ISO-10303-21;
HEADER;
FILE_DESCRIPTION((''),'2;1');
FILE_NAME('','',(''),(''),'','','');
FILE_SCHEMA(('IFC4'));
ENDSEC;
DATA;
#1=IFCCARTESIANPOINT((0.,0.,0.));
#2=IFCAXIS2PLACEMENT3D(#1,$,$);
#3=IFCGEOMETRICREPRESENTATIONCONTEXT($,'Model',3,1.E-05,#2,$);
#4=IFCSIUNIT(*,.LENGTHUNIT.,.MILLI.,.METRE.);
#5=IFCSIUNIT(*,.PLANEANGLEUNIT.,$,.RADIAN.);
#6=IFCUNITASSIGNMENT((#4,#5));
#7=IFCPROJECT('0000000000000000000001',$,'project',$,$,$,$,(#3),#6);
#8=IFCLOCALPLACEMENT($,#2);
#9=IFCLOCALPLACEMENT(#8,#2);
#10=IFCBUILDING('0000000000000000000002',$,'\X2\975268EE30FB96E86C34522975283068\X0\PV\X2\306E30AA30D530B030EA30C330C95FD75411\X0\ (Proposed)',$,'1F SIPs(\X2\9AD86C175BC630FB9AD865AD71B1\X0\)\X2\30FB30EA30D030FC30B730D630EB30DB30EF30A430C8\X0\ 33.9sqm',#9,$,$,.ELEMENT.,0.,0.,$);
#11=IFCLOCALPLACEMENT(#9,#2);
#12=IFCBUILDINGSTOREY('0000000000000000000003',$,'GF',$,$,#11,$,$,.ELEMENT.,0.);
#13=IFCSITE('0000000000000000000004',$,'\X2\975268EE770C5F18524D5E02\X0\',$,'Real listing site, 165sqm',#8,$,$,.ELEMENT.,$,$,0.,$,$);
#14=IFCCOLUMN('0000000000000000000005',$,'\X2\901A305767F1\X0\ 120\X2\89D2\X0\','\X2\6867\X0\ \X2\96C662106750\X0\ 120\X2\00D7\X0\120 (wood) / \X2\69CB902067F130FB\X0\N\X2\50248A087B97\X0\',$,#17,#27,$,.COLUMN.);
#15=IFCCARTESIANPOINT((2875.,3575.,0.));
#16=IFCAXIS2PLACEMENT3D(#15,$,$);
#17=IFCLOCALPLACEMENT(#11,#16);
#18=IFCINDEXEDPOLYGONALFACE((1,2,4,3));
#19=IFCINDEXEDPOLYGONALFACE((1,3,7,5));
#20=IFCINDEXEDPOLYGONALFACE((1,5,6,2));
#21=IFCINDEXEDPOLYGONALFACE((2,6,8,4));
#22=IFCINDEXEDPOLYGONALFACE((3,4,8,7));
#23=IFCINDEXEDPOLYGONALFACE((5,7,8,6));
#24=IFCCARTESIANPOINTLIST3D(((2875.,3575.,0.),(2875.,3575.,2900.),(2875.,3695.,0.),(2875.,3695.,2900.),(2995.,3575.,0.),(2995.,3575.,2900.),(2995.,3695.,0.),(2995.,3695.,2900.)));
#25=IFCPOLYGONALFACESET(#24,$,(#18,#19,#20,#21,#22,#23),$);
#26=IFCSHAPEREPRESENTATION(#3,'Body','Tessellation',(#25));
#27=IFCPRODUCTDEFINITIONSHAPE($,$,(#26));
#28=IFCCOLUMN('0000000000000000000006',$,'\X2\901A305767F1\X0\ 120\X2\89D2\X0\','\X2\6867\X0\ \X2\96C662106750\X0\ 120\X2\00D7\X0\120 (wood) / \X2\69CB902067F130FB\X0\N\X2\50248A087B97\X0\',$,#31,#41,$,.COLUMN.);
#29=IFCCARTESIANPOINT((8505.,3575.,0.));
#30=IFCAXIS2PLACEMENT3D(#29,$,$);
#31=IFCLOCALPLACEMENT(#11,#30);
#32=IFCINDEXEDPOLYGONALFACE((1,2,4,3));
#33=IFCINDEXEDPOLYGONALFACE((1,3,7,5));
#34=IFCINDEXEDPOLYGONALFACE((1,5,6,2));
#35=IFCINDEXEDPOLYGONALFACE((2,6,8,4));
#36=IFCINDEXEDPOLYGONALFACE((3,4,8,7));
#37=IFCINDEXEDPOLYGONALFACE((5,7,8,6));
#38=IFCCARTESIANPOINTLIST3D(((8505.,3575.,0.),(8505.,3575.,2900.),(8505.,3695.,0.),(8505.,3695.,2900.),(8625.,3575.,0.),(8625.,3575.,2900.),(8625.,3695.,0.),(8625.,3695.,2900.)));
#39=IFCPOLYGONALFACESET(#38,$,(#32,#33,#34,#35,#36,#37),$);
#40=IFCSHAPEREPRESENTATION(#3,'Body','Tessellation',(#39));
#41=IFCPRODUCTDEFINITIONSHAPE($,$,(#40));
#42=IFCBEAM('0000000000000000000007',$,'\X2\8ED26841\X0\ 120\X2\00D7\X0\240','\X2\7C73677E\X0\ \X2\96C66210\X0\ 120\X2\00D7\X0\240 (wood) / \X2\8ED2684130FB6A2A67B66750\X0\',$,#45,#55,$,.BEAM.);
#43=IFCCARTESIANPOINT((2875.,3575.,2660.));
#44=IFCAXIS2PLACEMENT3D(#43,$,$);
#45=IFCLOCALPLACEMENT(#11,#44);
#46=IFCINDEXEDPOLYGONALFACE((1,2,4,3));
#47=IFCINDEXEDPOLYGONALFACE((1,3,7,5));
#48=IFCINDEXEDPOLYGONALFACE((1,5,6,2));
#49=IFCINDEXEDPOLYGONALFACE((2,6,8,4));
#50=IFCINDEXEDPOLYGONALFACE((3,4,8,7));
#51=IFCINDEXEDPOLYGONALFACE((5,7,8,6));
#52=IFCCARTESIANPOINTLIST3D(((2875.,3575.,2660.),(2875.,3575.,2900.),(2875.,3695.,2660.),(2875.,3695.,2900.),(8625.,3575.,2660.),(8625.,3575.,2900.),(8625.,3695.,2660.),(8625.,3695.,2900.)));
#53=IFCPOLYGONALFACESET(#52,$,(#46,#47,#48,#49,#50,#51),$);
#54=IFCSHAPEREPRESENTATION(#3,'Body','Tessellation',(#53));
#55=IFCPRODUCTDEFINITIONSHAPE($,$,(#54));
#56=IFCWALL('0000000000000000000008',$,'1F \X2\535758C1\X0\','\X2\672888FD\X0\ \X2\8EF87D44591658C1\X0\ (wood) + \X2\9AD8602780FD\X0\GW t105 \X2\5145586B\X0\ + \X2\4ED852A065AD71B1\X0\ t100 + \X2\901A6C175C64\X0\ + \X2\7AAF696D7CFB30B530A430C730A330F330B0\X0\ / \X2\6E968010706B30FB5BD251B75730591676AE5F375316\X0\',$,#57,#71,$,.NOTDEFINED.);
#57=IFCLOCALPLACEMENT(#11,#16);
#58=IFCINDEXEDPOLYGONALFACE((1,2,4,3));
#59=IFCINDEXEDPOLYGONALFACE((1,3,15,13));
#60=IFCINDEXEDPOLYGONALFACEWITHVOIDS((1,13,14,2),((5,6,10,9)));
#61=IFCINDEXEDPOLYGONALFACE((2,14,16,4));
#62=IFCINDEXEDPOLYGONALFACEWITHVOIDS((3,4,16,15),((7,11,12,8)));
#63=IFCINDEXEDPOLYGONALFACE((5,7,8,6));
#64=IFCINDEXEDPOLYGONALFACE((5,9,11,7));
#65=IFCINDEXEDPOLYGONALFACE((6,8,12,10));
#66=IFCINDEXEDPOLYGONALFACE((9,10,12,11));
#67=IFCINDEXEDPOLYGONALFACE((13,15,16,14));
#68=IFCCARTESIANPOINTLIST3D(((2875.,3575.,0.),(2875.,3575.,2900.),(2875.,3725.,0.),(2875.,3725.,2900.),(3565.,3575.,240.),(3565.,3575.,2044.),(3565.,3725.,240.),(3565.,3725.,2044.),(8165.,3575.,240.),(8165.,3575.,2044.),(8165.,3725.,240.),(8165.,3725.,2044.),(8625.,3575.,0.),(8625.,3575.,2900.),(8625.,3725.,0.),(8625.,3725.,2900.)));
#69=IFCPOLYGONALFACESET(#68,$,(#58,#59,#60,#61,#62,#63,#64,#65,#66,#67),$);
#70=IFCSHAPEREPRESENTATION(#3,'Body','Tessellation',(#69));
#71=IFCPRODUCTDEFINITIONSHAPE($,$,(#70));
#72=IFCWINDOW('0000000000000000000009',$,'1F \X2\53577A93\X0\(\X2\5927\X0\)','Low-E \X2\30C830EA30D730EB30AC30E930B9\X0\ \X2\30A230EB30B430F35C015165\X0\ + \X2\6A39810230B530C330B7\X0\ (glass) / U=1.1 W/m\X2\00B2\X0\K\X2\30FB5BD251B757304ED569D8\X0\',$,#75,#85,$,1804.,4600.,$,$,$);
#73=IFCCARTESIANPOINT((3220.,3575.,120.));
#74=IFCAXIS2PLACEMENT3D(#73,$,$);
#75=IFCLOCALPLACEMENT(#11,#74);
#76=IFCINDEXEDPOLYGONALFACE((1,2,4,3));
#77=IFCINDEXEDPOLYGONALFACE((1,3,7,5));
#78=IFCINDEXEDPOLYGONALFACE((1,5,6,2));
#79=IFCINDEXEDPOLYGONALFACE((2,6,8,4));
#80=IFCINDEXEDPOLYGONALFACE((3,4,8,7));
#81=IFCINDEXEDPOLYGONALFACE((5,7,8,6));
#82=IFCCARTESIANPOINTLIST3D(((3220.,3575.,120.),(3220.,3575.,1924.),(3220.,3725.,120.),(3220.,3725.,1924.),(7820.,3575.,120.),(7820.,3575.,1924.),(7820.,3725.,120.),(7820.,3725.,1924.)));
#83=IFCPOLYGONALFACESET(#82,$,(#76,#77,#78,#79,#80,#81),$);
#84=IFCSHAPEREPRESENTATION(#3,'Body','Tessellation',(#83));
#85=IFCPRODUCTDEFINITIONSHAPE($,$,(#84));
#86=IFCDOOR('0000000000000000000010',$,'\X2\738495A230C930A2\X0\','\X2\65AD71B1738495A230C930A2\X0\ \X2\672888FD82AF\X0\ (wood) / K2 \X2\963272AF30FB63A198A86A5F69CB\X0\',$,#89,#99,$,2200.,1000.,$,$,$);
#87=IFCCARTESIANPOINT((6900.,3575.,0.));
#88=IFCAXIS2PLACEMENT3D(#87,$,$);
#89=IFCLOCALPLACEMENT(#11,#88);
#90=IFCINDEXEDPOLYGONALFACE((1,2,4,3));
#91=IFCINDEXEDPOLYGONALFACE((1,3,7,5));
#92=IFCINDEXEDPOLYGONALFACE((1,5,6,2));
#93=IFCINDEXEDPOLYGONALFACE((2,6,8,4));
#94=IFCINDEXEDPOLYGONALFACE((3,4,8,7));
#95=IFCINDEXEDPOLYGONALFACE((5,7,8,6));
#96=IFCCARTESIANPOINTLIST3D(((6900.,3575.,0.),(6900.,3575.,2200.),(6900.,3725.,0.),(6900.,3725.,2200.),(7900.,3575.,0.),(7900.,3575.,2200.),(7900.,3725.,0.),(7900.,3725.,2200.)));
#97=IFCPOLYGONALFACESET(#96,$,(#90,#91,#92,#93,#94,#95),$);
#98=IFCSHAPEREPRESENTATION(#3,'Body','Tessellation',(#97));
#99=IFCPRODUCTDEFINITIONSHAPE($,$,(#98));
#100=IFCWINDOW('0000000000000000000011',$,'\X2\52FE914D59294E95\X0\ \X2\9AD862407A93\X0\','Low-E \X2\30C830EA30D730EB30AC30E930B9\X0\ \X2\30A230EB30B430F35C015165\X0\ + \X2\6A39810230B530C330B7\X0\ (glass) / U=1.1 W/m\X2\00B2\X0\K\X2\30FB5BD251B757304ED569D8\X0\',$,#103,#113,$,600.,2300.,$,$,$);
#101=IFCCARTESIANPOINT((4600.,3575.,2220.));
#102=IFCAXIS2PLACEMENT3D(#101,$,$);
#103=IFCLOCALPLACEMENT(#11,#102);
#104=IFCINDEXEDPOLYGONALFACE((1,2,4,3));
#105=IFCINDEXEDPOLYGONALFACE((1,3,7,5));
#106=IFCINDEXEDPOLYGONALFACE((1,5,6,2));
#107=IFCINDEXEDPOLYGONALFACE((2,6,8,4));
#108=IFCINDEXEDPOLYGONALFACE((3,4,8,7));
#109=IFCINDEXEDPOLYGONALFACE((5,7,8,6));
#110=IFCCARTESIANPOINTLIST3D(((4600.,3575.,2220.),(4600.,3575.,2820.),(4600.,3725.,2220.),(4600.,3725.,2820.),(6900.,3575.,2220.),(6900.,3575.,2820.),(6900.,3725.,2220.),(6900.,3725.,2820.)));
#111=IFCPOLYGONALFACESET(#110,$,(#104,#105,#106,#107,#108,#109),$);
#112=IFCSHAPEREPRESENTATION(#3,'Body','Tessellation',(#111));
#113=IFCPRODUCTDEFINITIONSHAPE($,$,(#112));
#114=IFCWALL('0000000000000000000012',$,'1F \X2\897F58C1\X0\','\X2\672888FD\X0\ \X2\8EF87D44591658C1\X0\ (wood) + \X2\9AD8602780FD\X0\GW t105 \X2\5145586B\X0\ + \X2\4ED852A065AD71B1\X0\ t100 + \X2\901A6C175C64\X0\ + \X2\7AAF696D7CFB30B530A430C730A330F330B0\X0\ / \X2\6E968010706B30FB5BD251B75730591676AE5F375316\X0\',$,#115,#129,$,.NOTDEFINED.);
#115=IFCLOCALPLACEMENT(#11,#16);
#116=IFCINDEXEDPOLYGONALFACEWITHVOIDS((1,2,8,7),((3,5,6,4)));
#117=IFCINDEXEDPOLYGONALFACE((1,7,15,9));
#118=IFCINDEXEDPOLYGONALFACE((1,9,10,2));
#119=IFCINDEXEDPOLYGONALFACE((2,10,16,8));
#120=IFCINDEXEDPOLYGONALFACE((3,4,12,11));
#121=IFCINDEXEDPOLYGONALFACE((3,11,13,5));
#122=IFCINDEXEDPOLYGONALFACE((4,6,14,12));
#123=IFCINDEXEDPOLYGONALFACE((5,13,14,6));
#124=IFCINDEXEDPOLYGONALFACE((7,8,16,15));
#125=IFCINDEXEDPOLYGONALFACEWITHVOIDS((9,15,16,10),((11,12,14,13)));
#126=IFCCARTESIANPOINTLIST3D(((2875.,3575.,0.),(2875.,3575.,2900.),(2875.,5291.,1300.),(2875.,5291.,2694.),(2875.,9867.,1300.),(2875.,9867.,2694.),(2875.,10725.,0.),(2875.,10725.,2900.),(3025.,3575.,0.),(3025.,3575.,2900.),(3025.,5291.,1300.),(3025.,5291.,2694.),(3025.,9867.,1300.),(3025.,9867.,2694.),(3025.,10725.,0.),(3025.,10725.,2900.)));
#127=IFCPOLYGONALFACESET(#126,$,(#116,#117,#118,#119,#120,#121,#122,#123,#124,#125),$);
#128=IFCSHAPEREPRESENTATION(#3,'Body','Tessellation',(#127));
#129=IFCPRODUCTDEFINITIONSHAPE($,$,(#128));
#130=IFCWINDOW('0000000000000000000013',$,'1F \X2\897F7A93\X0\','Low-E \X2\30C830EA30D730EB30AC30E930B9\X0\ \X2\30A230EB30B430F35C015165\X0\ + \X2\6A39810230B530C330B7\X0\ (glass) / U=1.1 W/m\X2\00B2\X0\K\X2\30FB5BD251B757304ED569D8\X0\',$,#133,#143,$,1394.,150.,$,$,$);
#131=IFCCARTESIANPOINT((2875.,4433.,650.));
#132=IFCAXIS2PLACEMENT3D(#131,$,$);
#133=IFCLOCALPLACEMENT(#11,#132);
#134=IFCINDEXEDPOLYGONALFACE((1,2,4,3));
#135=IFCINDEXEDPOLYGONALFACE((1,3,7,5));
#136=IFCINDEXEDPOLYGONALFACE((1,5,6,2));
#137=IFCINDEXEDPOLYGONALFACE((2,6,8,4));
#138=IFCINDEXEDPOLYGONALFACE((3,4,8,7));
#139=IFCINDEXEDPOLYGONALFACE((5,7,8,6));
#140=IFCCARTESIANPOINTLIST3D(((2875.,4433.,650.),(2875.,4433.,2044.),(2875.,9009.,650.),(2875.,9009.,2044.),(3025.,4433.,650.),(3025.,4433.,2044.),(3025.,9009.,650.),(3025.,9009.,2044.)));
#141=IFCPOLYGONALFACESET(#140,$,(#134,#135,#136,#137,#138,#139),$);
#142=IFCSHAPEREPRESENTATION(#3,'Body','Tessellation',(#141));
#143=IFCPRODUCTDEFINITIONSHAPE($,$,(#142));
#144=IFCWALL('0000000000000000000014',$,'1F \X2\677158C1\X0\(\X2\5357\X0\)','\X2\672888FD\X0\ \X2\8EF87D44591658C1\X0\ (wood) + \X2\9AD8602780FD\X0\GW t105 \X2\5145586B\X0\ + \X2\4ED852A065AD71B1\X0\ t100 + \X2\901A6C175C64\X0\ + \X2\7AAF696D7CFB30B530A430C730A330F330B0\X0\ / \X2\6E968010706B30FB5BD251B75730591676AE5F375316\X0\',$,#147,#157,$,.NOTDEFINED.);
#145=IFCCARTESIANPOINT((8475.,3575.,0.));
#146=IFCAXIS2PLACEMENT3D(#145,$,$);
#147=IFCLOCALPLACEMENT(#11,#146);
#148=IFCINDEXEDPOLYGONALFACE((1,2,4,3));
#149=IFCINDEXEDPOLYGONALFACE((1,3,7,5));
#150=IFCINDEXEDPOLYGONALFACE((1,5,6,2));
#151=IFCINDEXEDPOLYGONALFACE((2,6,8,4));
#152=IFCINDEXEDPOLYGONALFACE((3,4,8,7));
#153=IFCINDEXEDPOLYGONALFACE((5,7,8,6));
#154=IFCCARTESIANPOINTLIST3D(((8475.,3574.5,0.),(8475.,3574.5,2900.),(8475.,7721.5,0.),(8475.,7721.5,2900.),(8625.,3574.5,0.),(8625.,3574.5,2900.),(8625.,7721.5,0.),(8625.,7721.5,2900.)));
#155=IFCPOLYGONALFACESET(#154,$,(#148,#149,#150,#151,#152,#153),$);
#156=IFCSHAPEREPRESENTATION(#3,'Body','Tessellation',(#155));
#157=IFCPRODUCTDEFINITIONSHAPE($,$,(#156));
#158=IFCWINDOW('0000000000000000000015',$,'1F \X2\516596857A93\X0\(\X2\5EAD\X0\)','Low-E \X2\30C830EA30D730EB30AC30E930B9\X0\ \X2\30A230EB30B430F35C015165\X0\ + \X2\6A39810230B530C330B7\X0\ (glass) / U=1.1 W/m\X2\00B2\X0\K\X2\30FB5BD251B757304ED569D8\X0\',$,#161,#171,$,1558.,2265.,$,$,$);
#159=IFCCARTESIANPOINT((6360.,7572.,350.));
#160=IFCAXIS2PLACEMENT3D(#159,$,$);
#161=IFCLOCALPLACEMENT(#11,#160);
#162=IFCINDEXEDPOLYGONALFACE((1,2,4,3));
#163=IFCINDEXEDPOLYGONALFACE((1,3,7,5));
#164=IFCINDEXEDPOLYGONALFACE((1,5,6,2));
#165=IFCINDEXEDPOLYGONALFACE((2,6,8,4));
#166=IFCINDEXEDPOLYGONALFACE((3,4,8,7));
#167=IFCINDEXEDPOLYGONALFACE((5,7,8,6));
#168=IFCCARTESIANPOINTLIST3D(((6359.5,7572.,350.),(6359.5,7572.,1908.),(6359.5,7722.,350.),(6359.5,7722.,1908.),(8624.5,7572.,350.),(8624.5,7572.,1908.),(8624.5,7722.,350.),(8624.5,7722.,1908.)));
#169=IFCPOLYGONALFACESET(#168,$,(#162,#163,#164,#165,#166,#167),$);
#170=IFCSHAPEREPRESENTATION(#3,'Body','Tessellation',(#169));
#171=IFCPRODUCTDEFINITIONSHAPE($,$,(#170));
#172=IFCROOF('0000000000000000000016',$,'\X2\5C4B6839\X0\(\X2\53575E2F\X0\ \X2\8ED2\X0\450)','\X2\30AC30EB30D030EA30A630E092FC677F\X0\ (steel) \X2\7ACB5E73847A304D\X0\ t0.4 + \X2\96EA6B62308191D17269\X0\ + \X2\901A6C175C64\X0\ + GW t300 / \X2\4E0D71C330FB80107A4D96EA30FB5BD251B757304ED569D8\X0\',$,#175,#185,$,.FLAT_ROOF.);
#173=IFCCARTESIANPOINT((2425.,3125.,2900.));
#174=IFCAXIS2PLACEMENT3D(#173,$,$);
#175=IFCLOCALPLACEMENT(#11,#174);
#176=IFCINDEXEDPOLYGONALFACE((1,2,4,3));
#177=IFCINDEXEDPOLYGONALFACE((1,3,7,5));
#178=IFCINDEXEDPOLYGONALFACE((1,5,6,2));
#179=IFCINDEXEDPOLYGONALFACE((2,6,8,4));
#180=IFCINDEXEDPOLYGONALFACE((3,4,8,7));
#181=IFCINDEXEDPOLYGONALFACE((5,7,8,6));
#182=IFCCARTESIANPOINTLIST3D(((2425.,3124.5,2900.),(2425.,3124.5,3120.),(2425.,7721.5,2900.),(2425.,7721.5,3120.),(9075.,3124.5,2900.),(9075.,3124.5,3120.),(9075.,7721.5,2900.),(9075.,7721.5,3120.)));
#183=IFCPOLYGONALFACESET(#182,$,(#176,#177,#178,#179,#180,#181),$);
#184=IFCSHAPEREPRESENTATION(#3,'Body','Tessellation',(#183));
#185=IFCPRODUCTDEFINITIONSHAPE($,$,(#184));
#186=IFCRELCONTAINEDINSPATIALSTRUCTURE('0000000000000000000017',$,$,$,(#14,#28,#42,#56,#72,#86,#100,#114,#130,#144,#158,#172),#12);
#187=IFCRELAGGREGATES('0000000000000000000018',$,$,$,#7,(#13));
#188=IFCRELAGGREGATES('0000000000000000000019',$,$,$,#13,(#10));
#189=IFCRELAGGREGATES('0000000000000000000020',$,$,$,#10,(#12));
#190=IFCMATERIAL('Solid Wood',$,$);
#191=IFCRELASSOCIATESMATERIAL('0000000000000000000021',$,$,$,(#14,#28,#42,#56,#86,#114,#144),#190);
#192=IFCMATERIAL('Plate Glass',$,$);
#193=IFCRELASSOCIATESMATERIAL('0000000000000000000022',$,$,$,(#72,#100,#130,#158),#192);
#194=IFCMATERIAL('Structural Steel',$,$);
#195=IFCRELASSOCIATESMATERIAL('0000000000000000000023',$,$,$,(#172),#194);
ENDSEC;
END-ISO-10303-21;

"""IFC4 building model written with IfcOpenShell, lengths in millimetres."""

from ifc_helpers import new_model, si_unit, frame, frame_2d, origin, place, context, project, spatial, rectangle, extrude, material, element, fill, save


model = new_model("IFC4")

# Units and contexts
model_context = context("Model", 3, precision=1e-05, world=origin())
ifc_project = project(units=[si_unit("LENGTHUNIT", "METRE", prefix="MILLI"), si_unit("PLANEANGLEUNIT", "RADIAN")], contexts=[model_context])

# Site, building, storey
site_placement = place(None, origin())
site = spatial("IfcSite", under=ifc_project, at=site_placement, Name="青森県弘前市", ObjectType="Real listing site, 165sqm", CompositionType="ELEMENT", RefElevation=0.0)
building_placement = place(site_placement, origin())
building = spatial("IfcBuilding", under=site, at=building_placement, Name="青森・雨水利用とPVのオフグリッド志向 (Proposed)", ObjectType="1F SIPs(高気密・高断熱)・リバーシブルホワイト 33.9sqm", CompositionType="ELEMENT", ElevationOfRefHeight=0.0, ElevationOfTerrain=0.0)
storey_placement = place(building_placement, origin())
storey = spatial("IfcBuildingStorey", under=building, at=storey_placement, Name="GF", CompositionType="ELEMENT", Elevation=0.0)

# Columns
ifc_material_1 = material(Name="Solid Wood")
column_1_placement = place(storey_placement, frame((2875.0, 3575.0, 0.0)))
element("IfcColumn", 1, at=column_1_placement, inside=storey, material=ifc_material_1, Name="通し柱 120角", Description="桧 集成材 120×120 (wood) / 構造柱・N値計算", PredefinedType="COLUMN", context=model_context, shape_type="SweptSolid", body=[
    extrude(rectangle(XDim=120.0, YDim=120.0, at=frame_2d((60.0, 60.0))), frame((2875.0, 3575.0, 0.0)), (0.0, 0.0, 1.0), 2900.0),
])
column_2_placement = place(storey_placement, frame((8505.0, 3575.0, 0.0)))
element("IfcColumn", 2, at=column_2_placement, inside=storey, material=ifc_material_1, Name="通し柱 120角", Description="桧 集成材 120×120 (wood) / 構造柱・N値計算", PredefinedType="COLUMN", context=model_context, shape_type="SweptSolid", body=[
    extrude(rectangle(XDim=120.0, YDim=120.0, at=frame_2d((60.0, 60.0))), frame((8505.0, 3575.0, 0.0)), (0.0, 0.0, 1.0), 2900.0),
])

# Beam
beam_1_placement = place(storey_placement, frame((2875.0, 3575.0, 2660.0)))
element("IfcBeam", 3, at=beam_1_placement, inside=storey, material=ifc_material_1, Name="軒桁 120×240", Description="米松 集成 120×240 (wood) / 軒桁・横架材", PredefinedType="BEAM", context=model_context, shape_type="SweptSolid", body=[
    extrude(rectangle(XDim=5750.0, YDim=120.0, at=frame_2d((2875.0, 60.0))), frame((2875.0, 3575.0, 2660.0)), (0.0, 0.0, 1.0), 240.0),
])

# Wall, openings, windows, door
wall_1_placement = place(storey_placement, frame((2875.0, 3575.0, 0.0)))
wall_1 = element("IfcWall", 4, at=wall_1_placement, inside=storey, material=ifc_material_1, Name="1F 南壁", Description="木製 軸組外壁 (wood) + 高性能GW t105 充填 + 付加断熱 t100 + 通気層 + 窯業系サイディング / 準耐火・寒冷地外皮強化", PredefinedType="NOTDEFINED", context=model_context, shape_type="SweptSolid", body=[
    extrude(rectangle(XDim=5750.0, YDim=150.0, at=frame_2d((2875.0, 75.0))), frame((2875.0, 3575.0, 0.0)), (0.0, 0.0, 1.0), 2900.0),
])
opening_1_placement = place(storey_placement, frame((3220.0, 3575.0, 120.0)))
opening_1 = element("IfcOpeningElement", 5, at=opening_1_placement, cuts=wall_1, PredefinedType="NOTDEFINED", context=model_context, shape_type="SweptSolid", body=[
    extrude(rectangle(XDim=4600.0, YDim=150.0, at=frame_2d((2300.0, 75.0))), frame((3220.0, 3575.0, 120.0)), (0.0, 0.0, 1.0), 1804.0),
])
opening_2_placement = place(storey_placement, frame((6900.0, 3575.0, 0.0)))
opening_2 = element("IfcOpeningElement", 6, at=opening_2_placement, cuts=wall_1, PredefinedType="NOTDEFINED", context=model_context, shape_type="SweptSolid", body=[
    extrude(rectangle(XDim=1000.0, YDim=150.0, at=frame_2d((500.0, 75.0))), frame((6900.0, 3575.0, 0.0)), (0.0, 0.0, 1.0), 2200.0),
])
opening_3_placement = place(storey_placement, frame((4600.0, 3575.0, 2220.0)))
opening_3 = element("IfcOpeningElement", 7, at=opening_3_placement, cuts=wall_1, PredefinedType="NOTDEFINED", context=model_context, shape_type="SweptSolid", body=[
    extrude(rectangle(XDim=2300.0, YDim=150.0, at=frame_2d((1150.0, 75.0))), frame((4600.0, 3575.0, 2220.0)), (0.0, 0.0, 1.0), 600.0),
])
ifc_material_2 = material(Name="Plate Glass")
window_1_placement = place(storey_placement, frame((3220.0, 3575.0, 120.0)))
window_1 = element("IfcWindow", 8, at=window_1_placement, inside=storey, material=ifc_material_2, Name="1F 南窓(大)", Description="Low-E トリプルガラス アルゴン封入 + 樹脂サッシ (glass) / U=1.1 W/m²K・寒冷地仕様", OverallHeight=1804.0, OverallWidth=4600.0, context=model_context, shape_type="SweptSolid", body=[
    extrude(rectangle(XDim=4600.0, YDim=150.0, at=frame_2d((2300.0, 75.0))), frame((3220.0, 3575.0, 120.0)), (0.0, 0.0, 1.0), 1804.0),
])
fill(opening_1, window_1)
door_1_placement = place(storey_placement, frame((6900.0, 3575.0, 0.0)))
door_1 = element("IfcDoor", 9, at=door_1_placement, inside=storey, material=ifc_material_1, Name="玄関ドア", Description="断熱玄関ドア 木製芯 (wood) / K2 防犯・採風機構", OverallHeight=2200.0, OverallWidth=1000.0, context=model_context, shape_type="SweptSolid", body=[
    extrude(rectangle(XDim=1000.0, YDim=150.0, at=frame_2d((500.0, 75.0))), frame((6900.0, 3575.0, 0.0)), (0.0, 0.0, 1.0), 2200.0),
])
fill(opening_2, door_1)
window_2_placement = place(storey_placement, frame((4600.0, 3575.0, 2220.0)))
window_2 = element("IfcWindow", 10, at=window_2_placement, inside=storey, material=ifc_material_2, Name="勾配天井 高所窓", Description="Low-E トリプルガラス アルゴン封入 + 樹脂サッシ (glass) / U=1.1 W/m²K・寒冷地仕様", OverallHeight=600.0, OverallWidth=2300.0, context=model_context, shape_type="SweptSolid", body=[
    extrude(rectangle(XDim=2300.0, YDim=150.0, at=frame_2d((1150.0, 75.0))), frame((4600.0, 3575.0, 2220.0)), (0.0, 0.0, 1.0), 600.0),
])
fill(opening_3, window_2)

# Walls, openings, windows
wall_2_placement = place(storey_placement, frame((2875.0, 3575.0, 0.0)))
wall_2 = element("IfcWall", 11, at=wall_2_placement, inside=storey, material=ifc_material_1, Name="1F 西壁", Description="木製 軸組外壁 (wood) + 高性能GW t105 充填 + 付加断熱 t100 + 通気層 + 窯業系サイディング / 準耐火・寒冷地外皮強化", PredefinedType="NOTDEFINED", context=model_context, shape_type="SweptSolid", body=[
    extrude(rectangle(XDim=150.0, YDim=7150.0, at=frame_2d((75.0, 3575.0))), frame((2875.0, 3575.0, 0.0)), (0.0, 0.0, 1.0), 2900.0),
])
opening_4_placement = place(storey_placement, frame((2875.0, 4433.0, 650.0)))
opening_4 = element("IfcOpeningElement", 12, at=opening_4_placement, cuts=wall_2, PredefinedType="NOTDEFINED", context=model_context, shape_type="SweptSolid", body=[
    extrude(rectangle(XDim=150.0, YDim=4576.0, at=frame_2d((75.0, 2288.0))), frame((2875.0, 4433.0, 650.0)), (0.0, 0.0, 1.0), 1394.0),
])
window_3_placement = place(storey_placement, frame((2875.0, 4433.0, 650.0)))
window_3 = element("IfcWindow", 13, at=window_3_placement, inside=storey, material=ifc_material_2, Name="1F 西窓", Description="Low-E トリプルガラス アルゴン封入 + 樹脂サッシ (glass) / U=1.1 W/m²K・寒冷地仕様", OverallHeight=1394.0, OverallWidth=150.0, context=model_context, shape_type="SweptSolid", body=[
    extrude(rectangle(XDim=150.0, YDim=4576.0, at=frame_2d((75.0, 2288.0))), frame((2875.0, 4433.0, 650.0)), (0.0, 0.0, 1.0), 1394.0),
])
fill(opening_4, window_3)
wall_3_placement = place(storey_placement, frame((8475.0, 3575.0, 0.0)))
wall_3 = element("IfcWall", 14, at=wall_3_placement, inside=storey, material=ifc_material_1, Name="1F 東壁(南)", Description="木製 軸組外壁 (wood) + 高性能GW t105 充填 + 付加断熱 t100 + 通気層 + 窯業系サイディング / 準耐火・寒冷地外皮強化", PredefinedType="NOTDEFINED", context=model_context, shape_type="SweptSolid", body=[
    extrude(rectangle(XDim=150.0, YDim=4147.0, at=frame_2d((75.0, 2073.0))), frame((8475.0, 3575.0, 0.0)), (0.0, 0.0, 1.0), 2900.0),
])
opening_5_placement = place(storey_placement, frame((6360.0, 7572.0, 350.0)))
opening_5 = element("IfcOpeningElement", 15, at=opening_5_placement, cuts=wall_3, PredefinedType="NOTDEFINED", context=model_context, shape_type="SweptSolid", body=[
    extrude(rectangle(XDim=2265.0, YDim=150.0, at=frame_2d((1132.0, 75.0))), frame((6360.0, 7572.0, 350.0)), (0.0, 0.0, 1.0), 1558.0),
])
window_4_placement = place(storey_placement, frame((6360.0, 7572.0, 350.0)))
window_4 = element("IfcWindow", 16, at=window_4_placement, inside=storey, material=ifc_material_2, Name="1F 入隅窓(庭)", Description="Low-E トリプルガラス アルゴン封入 + 樹脂サッシ (glass) / U=1.1 W/m²K・寒冷地仕様", OverallHeight=1558.0, OverallWidth=2265.0, context=model_context, shape_type="SweptSolid", body=[
    extrude(rectangle(XDim=2265.0, YDim=150.0, at=frame_2d((1132.0, 75.0))), frame((6360.0, 7572.0, 350.0)), (0.0, 0.0, 1.0), 1558.0),
])
fill(opening_5, window_4)

# Roof
ifc_material_3 = material(Name="Structural Steel")
roof_placement = place(storey_placement, frame((2425.0, 3125.0, 2900.0)))
element("IfcRoof", 17, at=roof_placement, inside=storey, material=ifc_material_3, Name="屋根(南帯 軒450)", Description="ガルバリウム鋼板 (steel) 立平葺き t0.4 + 雪止め金物 + 通気層 + GW t300 / 不燃・耐積雪・寒冷地仕様", PredefinedType="FLAT_ROOF", context=model_context, shape_type="SweptSolid", body=[
    extrude(rectangle(XDim=6650.0, YDim=4597.0, at=frame_2d((3325.0, 2298.0))), frame((2425.0, 3125.0, 2900.0)), (0.0, 0.0, 1.0), 220.0),
])

save(model, "model.ifc")
